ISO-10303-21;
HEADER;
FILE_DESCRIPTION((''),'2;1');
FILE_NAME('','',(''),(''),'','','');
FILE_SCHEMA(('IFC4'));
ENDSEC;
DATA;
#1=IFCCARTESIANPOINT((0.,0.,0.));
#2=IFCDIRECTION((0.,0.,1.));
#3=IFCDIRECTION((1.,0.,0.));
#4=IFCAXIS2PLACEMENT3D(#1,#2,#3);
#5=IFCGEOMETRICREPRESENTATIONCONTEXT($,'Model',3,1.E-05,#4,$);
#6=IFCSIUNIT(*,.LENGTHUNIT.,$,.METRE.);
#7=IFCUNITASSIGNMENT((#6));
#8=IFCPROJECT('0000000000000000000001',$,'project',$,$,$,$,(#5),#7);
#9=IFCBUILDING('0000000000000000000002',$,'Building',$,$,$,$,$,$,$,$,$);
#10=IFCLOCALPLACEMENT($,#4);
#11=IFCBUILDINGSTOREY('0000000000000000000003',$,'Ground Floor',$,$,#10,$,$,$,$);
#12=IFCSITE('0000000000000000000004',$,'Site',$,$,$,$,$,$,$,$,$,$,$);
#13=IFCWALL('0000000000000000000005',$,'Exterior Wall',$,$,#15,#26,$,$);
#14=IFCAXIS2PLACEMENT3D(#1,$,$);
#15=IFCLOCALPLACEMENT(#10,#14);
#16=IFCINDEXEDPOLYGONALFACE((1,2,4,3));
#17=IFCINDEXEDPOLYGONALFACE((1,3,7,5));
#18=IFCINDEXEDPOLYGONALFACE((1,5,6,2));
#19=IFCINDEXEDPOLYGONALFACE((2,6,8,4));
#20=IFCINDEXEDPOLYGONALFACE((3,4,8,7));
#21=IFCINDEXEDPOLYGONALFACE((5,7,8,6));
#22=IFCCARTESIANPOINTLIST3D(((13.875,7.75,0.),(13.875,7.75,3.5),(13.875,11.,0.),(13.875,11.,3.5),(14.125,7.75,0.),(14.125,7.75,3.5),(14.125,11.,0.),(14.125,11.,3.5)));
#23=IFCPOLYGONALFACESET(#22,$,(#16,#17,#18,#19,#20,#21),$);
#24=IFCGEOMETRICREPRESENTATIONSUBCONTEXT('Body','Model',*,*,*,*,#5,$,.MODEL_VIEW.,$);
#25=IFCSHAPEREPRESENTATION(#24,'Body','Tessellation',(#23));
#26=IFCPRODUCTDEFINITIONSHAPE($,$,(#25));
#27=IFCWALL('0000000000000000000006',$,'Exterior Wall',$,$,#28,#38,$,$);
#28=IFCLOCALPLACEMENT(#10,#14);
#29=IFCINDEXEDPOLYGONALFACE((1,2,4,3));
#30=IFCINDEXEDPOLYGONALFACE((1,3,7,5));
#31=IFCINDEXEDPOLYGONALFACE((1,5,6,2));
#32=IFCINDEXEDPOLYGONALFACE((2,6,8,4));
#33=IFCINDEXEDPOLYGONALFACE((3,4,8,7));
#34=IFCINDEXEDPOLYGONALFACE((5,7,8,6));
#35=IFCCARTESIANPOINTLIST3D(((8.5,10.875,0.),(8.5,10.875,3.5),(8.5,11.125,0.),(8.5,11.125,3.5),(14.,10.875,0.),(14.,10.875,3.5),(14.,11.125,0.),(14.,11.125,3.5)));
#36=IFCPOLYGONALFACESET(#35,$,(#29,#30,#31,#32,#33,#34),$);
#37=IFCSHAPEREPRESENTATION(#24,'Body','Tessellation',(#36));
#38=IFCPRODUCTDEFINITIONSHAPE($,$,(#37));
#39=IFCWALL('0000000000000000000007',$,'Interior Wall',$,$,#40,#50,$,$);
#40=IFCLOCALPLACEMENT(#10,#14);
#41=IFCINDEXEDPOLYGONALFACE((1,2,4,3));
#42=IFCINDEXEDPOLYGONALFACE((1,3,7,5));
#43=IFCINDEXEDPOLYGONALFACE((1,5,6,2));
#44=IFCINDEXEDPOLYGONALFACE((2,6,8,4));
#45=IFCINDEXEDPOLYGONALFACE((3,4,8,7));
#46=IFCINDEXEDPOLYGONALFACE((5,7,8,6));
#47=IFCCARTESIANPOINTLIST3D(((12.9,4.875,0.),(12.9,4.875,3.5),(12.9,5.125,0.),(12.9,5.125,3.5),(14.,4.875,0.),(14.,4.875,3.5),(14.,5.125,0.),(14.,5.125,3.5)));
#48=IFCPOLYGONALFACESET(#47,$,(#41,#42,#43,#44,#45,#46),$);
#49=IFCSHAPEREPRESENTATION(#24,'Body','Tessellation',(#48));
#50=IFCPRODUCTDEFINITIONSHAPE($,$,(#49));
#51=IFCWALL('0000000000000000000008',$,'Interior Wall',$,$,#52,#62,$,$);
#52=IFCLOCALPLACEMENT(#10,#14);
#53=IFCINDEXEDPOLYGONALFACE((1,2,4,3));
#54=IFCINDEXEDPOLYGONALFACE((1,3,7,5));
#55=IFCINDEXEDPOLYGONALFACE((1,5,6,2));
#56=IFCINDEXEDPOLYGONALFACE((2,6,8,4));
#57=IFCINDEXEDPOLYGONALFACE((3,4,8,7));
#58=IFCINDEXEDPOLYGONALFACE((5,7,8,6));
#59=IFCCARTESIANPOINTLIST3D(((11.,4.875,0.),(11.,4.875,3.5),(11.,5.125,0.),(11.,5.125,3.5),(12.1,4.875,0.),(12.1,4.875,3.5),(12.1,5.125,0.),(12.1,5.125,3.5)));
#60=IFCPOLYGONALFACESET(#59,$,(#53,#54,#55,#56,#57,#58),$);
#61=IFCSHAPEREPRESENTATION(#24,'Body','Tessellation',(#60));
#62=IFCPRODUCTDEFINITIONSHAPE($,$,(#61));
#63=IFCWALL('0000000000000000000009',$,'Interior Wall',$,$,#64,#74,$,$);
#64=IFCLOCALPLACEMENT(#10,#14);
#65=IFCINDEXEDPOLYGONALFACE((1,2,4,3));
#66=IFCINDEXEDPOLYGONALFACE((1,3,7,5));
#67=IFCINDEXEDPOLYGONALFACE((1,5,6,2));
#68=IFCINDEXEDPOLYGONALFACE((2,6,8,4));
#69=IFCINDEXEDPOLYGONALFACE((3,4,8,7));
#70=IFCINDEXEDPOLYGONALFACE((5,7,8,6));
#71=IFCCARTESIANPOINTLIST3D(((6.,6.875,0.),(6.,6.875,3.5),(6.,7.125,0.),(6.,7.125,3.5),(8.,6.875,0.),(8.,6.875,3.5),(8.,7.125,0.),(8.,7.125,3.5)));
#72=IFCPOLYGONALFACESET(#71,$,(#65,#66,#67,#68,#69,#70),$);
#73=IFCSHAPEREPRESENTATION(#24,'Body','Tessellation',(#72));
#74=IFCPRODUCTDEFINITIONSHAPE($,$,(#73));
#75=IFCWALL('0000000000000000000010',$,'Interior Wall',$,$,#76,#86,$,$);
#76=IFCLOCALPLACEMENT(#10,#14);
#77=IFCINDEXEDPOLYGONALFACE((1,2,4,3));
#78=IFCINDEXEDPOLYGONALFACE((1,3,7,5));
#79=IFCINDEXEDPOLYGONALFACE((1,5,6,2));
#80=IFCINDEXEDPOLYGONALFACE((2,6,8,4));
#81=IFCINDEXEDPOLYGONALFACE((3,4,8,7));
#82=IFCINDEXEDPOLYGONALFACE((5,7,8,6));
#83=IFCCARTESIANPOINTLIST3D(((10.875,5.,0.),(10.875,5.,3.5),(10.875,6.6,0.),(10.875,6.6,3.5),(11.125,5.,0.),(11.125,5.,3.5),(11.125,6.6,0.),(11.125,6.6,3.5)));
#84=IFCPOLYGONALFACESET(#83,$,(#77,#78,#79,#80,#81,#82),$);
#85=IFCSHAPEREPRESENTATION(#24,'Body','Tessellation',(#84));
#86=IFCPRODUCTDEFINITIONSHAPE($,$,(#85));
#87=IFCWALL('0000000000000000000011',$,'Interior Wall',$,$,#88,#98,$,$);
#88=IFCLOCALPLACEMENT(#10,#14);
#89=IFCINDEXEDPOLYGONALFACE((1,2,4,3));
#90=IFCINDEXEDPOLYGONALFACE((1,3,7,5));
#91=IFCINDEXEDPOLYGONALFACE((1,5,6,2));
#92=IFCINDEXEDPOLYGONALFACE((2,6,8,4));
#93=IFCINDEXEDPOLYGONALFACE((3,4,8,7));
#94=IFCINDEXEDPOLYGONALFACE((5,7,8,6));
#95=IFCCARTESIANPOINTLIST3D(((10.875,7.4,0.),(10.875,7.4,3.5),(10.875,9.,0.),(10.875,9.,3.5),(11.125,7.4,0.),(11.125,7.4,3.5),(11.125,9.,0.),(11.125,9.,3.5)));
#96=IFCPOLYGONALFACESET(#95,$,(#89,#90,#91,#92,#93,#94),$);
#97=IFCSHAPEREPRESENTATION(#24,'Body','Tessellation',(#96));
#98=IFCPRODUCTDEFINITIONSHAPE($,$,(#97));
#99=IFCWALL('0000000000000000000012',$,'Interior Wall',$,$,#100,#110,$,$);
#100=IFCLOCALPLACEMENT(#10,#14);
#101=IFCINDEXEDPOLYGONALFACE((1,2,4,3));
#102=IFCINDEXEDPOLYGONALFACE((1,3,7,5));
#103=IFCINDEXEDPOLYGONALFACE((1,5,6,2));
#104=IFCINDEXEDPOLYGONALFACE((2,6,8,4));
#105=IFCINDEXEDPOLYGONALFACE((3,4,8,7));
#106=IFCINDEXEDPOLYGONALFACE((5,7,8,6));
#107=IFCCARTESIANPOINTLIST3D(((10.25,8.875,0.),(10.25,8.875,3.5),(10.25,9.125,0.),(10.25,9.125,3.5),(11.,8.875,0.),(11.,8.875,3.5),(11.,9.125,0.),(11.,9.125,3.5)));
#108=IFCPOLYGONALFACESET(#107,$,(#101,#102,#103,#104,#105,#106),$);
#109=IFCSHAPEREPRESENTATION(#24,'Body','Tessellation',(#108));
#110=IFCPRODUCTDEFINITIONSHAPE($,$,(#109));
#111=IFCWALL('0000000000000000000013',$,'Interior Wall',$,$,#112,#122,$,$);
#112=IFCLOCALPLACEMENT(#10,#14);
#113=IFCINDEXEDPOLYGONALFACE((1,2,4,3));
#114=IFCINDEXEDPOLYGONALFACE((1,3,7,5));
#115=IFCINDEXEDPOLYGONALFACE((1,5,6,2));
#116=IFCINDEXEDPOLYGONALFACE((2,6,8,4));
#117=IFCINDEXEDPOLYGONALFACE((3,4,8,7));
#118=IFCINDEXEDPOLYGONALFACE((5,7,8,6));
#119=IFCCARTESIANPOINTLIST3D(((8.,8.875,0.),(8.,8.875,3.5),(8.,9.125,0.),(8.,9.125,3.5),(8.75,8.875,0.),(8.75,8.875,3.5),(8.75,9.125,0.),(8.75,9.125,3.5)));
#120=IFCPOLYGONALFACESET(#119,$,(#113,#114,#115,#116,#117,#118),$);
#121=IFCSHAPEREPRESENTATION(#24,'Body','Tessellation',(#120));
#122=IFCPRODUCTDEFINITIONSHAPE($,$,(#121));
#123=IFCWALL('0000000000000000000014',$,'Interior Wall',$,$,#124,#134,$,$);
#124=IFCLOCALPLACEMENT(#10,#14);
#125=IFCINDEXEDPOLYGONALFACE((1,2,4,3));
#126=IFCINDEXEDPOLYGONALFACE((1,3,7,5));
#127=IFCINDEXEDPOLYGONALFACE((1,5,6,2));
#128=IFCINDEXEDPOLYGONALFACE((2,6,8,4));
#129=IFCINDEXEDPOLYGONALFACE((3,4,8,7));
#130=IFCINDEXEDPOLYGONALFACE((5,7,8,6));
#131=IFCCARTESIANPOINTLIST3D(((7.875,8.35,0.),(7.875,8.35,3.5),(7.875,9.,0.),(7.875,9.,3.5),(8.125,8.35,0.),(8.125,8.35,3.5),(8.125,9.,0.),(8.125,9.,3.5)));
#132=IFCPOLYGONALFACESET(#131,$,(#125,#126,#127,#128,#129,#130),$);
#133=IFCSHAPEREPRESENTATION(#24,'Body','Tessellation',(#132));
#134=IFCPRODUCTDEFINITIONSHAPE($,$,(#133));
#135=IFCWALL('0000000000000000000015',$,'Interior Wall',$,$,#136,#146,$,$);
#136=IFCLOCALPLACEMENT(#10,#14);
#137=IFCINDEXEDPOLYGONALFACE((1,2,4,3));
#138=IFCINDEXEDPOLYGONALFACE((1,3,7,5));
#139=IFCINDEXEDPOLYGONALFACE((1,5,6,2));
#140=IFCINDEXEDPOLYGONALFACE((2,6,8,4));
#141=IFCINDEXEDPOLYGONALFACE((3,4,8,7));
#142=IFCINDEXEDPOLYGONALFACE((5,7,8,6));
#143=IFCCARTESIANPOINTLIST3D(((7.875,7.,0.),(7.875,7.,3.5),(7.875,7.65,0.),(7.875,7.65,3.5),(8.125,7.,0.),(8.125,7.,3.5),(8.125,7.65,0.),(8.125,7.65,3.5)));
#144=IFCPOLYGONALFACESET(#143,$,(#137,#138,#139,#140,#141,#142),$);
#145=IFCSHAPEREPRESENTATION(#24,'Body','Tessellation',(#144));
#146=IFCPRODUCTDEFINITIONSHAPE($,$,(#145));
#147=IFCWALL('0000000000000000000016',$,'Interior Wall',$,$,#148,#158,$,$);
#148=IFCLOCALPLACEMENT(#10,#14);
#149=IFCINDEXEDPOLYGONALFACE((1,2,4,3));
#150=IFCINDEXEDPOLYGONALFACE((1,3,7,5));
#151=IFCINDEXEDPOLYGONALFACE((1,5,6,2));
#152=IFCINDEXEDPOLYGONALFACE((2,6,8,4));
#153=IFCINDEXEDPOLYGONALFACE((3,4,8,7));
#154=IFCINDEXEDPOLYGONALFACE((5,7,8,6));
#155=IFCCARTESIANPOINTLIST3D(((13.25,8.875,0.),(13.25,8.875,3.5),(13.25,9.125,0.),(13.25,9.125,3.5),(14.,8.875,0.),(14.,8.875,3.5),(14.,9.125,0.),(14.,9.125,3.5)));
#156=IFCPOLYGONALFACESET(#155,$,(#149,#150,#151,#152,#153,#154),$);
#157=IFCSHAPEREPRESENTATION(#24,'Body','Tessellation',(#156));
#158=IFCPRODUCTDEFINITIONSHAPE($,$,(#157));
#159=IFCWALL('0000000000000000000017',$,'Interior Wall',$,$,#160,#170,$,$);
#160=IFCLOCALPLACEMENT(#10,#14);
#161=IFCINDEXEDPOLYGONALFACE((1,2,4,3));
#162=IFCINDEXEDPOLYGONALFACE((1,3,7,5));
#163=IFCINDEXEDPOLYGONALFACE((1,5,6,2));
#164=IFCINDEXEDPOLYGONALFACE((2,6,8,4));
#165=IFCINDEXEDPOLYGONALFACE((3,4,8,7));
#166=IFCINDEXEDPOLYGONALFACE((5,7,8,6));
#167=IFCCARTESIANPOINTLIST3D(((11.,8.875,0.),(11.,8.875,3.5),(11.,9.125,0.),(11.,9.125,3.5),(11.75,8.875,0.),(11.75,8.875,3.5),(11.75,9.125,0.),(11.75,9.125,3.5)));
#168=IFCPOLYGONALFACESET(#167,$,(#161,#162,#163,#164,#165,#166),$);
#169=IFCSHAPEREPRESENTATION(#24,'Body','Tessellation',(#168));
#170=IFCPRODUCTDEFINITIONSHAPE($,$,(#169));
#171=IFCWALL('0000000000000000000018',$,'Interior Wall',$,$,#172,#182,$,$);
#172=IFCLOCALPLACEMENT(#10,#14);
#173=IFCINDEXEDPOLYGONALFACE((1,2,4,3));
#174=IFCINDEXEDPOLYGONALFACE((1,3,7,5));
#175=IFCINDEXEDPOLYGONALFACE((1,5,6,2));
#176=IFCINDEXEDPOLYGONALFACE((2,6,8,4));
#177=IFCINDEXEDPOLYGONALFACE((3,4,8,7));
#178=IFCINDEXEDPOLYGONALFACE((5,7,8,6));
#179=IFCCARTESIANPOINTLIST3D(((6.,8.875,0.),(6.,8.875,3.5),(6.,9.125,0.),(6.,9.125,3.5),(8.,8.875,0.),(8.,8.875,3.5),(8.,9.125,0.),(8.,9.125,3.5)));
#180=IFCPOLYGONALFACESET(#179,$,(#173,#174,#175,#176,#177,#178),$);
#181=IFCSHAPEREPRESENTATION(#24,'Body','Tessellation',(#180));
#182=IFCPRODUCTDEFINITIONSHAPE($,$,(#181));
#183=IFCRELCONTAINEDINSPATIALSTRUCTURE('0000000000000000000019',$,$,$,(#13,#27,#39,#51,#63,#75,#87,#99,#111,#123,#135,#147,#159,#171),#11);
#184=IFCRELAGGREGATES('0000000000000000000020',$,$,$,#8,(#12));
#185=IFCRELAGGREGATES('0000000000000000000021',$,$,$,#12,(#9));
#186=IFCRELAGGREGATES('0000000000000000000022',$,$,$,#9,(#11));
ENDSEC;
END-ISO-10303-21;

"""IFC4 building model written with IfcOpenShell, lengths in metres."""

from ifc_helpers import new_model, si_unit, frame, origin_with_axes, place, context, subcontext, project, spatial, indexed_curve, outline, extrude, element, save


model = new_model("IFC4")

# Units and contexts
model_context = context("Model", 3, precision=1e-05, world=origin_with_axes())
body_context = subcontext(model_context, "Body", "Model", "MODEL_VIEW")
ifc_project = project(units=[si_unit("LENGTHUNIT", "METRE")], contexts=[model_context])

# Site, building, storey
site = spatial("IfcSite", under=ifc_project, Name="Site")
building = spatial("IfcBuilding", under=site, Name="Building")
storey_placement = place(None, origin_with_axes())
storey = spatial("IfcBuildingStorey", under=building, at=storey_placement, Name="Ground Floor")

# Walls
wall_1_placement = place(storey_placement, frame((14.0, 7.75, 0.0), z_axis=(0.0, 0.0, 1.0), x_axis=(0.0, 1.0, 0.0)))
element("IfcWall", 1, at=wall_1_placement, inside=storey, Name="Exterior Wall", context=body_context, shape_type="SweptSolid", body=[
    extrude(outline(indexed_curve([(0.0, 0.0), (0.0, 0.25), (3.25, 0.25), (3.25, 0.0), (0.0, 0.0)], self_intersect=False)), frame((0.0, -0.125, 0.0), z_axis=(0.0, 0.0, 1.0), x_axis=(1.0, 0.0, 0.0)), (0.0, 0.0, 1.0), 3.5),
])
wall_2_placement = place(storey_placement, frame((14.0, 11.0, 0.0), z_axis=(0.0, 0.0, 1.0), x_axis=(-1.0, 0.0, 0.0)))
element("IfcWall", 2, at=wall_2_placement, inside=storey, Name="Exterior Wall", context=body_context, shape_type="SweptSolid", body=[
    extrude(outline(indexed_curve([(0.0, 0.0), (0.0, 0.25), (5.5, 0.25), (5.5, 0.0), (0.0, 0.0)], self_intersect=False)), frame((0.0, -0.125, 0.0), z_axis=(0.0, 0.0, 1.0), x_axis=(1.0, 0.0, 0.0)), (0.0, 0.0, 1.0), 3.5),
])
for number, where, z_axis, x_axis, name in (
    (3, (14.0, 5.0, 0.0), (0.0, 0.0, 1.0), (-1.0, 0.0, 0.0), "Interior Wall"),
    (4, (12.1, 5.0, 0.0), (0.0, 0.0, 1.0), (-1.0, 0.0, 0.0), "Interior Wall"),
):
    element("IfcWall", number, at=place(storey_placement, frame(where, z_axis=z_axis, x_axis=x_axis)), inside=storey, Name=name, context=body_context, shape_type="SweptSolid", body=[
        extrude(outline(indexed_curve([(0.0, 0.0), (0.0, 0.25), (1.1, 0.25), (1.1, 0.0), (0.0, 0.0)], self_intersect=False)), frame((0.0, -0.125, 0.0), z_axis=(0.0, 0.0, 1.0), x_axis=(1.0, 0.0, 0.0)), (0.0, 0.0, 1.0), 3.5),
    ])
wall_3_placement = place(storey_placement, frame((8.0, 7.0, 0.0), z_axis=(0.0, 0.0, 1.0), x_axis=(-1.0, 0.0, 0.0)))
element("IfcWall", 5, at=wall_3_placement, inside=storey, Name="Interior Wall", context=body_context, shape_type="SweptSolid", body=[
    extrude(outline(indexed_curve([(0.0, 0.0), (0.0, 0.25), (2.0, 0.25), (2.0, 0.0), (0.0, 0.0)], self_intersect=False)), frame((0.0, -0.125, 0.0), z_axis=(0.0, 0.0, 1.0), x_axis=(1.0, 0.0, 0.0)), (0.0, 0.0, 1.0), 3.5),
])
for number, where, z_axis, x_axis, name in (
    (6, (11.0, 5.0, 0.0), (0.0, 0.0, 1.0), (0.0, 1.0, 0.0), "Interior Wall"),
    (7, (11.0, 7.4, 0.0), (0.0, 0.0, 1.0), (0.0, 1.0, 0.0), "Interior Wall"),
):
    element("IfcWall", number, at=place(storey_placement, frame(where, z_axis=z_axis, x_axis=x_axis)), inside=storey, Name=name, context=body_context, shape_type="SweptSolid", body=[
        extrude(outline(indexed_curve([(0.0, 0.0), (0.0, 0.25), (1.6, 0.25), (1.6, 0.0), (0.0, 0.0)], self_intersect=False)), frame((0.0, -0.125, 0.0), z_axis=(0.0, 0.0, 1.0), x_axis=(1.0, 0.0, 0.0)), (0.0, 0.0, 1.0), 3.5),
    ])
for number, where, z_axis, x_axis, name in (
    (8, (11.0, 9.0, 0.0), (0.0, 0.0, 1.0), (-1.0, 0.0, 0.0), "Interior Wall"),
    (9, (8.75, 9.0, 0.0), (0.0, 0.0, 1.0), (-1.0, 0.0, 0.0), "Interior Wall"),
):
    element("IfcWall", number, at=place(storey_placement, frame(where, z_axis=z_axis, x_axis=x_axis)), inside=storey, Name=name, context=body_context, shape_type="SweptSolid", body=[
        extrude(outline(indexed_curve([(0.0, 0.0), (0.0, 0.25), (0.75, 0.25), (0.75, 0.0), (0.0, 0.0)], self_intersect=False)), frame((0.0, -0.125, 0.0), z_axis=(0.0, 0.0, 1.0), x_axis=(1.0, 0.0, 0.0)), (0.0, 0.0, 1.0), 3.5),
    ])
for number, where, z_axis, x_axis, name in (
    (10, (8.0, 9.0, 0.0), (0.0, 0.0, 1.0), (0.0, -1.0, 0.0), "Interior Wall"),
    (11, (8.0, 7.65, 0.0), (0.0, 0.0, 1.0), (0.0, -1.0, 0.0), "Interior Wall"),
):
    element("IfcWall", number, at=place(storey_placement, frame(where, z_axis=z_axis, x_axis=x_axis)), inside=storey, Name=name, context=body_context, shape_type="SweptSolid", body=[
        extrude(outline(indexed_curve([(0.0, 0.0), (0.0, 0.25), (0.65, 0.25), (0.65, 0.0), (0.0, 0.0)], self_intersect=False)), frame((0.0, -0.125, 0.0), z_axis=(0.0, 0.0, 1.0), x_axis=(1.0, 0.0, 0.0)), (0.0, 0.0, 1.0), 3.5),
    ])
for number, where, z_axis, x_axis, name in (
    (12, (14.0, 9.0, 0.0), (0.0, 0.0, 1.0), (-1.0, 0.0, 0.0), "Interior Wall"),
    (13, (11.75, 9.0, 0.0), (0.0, 0.0, 1.0), (-1.0, 0.0, 0.0), "Interior Wall"),
):
    element("IfcWall", number, at=place(storey_placement, frame(where, z_axis=z_axis, x_axis=x_axis)), inside=storey, Name=name, context=body_context, shape_type="SweptSolid", body=[
        extrude(outline(indexed_curve([(0.0, 0.0), (0.0, 0.25), (0.75, 0.25), (0.75, 0.0), (0.0, 0.0)], self_intersect=False)), frame((0.0, -0.125, 0.0), z_axis=(0.0, 0.0, 1.0), x_axis=(1.0, 0.0, 0.0)), (0.0, 0.0, 1.0), 3.5),
    ])
wall_4_placement = place(storey_placement, frame((8.0, 9.0, 0.0), z_axis=(0.0, 0.0, 1.0), x_axis=(-1.0, 0.0, 0.0)))
element("IfcWall", 14, at=wall_4_placement, inside=storey, Name="Interior Wall", context=body_context, shape_type="SweptSolid", body=[
    extrude(outline(indexed_curve([(0.0, 0.0), (0.0, 0.25), (2.0, 0.25), (2.0, 0.0), (0.0, 0.0)], self_intersect=False)), frame((0.0, -0.125, 0.0), z_axis=(0.0, 0.0, 1.0), x_axis=(1.0, 0.0, 0.0)), (0.0, 0.0, 1.0), 3.5),
])

save(model, "model.ifc")
